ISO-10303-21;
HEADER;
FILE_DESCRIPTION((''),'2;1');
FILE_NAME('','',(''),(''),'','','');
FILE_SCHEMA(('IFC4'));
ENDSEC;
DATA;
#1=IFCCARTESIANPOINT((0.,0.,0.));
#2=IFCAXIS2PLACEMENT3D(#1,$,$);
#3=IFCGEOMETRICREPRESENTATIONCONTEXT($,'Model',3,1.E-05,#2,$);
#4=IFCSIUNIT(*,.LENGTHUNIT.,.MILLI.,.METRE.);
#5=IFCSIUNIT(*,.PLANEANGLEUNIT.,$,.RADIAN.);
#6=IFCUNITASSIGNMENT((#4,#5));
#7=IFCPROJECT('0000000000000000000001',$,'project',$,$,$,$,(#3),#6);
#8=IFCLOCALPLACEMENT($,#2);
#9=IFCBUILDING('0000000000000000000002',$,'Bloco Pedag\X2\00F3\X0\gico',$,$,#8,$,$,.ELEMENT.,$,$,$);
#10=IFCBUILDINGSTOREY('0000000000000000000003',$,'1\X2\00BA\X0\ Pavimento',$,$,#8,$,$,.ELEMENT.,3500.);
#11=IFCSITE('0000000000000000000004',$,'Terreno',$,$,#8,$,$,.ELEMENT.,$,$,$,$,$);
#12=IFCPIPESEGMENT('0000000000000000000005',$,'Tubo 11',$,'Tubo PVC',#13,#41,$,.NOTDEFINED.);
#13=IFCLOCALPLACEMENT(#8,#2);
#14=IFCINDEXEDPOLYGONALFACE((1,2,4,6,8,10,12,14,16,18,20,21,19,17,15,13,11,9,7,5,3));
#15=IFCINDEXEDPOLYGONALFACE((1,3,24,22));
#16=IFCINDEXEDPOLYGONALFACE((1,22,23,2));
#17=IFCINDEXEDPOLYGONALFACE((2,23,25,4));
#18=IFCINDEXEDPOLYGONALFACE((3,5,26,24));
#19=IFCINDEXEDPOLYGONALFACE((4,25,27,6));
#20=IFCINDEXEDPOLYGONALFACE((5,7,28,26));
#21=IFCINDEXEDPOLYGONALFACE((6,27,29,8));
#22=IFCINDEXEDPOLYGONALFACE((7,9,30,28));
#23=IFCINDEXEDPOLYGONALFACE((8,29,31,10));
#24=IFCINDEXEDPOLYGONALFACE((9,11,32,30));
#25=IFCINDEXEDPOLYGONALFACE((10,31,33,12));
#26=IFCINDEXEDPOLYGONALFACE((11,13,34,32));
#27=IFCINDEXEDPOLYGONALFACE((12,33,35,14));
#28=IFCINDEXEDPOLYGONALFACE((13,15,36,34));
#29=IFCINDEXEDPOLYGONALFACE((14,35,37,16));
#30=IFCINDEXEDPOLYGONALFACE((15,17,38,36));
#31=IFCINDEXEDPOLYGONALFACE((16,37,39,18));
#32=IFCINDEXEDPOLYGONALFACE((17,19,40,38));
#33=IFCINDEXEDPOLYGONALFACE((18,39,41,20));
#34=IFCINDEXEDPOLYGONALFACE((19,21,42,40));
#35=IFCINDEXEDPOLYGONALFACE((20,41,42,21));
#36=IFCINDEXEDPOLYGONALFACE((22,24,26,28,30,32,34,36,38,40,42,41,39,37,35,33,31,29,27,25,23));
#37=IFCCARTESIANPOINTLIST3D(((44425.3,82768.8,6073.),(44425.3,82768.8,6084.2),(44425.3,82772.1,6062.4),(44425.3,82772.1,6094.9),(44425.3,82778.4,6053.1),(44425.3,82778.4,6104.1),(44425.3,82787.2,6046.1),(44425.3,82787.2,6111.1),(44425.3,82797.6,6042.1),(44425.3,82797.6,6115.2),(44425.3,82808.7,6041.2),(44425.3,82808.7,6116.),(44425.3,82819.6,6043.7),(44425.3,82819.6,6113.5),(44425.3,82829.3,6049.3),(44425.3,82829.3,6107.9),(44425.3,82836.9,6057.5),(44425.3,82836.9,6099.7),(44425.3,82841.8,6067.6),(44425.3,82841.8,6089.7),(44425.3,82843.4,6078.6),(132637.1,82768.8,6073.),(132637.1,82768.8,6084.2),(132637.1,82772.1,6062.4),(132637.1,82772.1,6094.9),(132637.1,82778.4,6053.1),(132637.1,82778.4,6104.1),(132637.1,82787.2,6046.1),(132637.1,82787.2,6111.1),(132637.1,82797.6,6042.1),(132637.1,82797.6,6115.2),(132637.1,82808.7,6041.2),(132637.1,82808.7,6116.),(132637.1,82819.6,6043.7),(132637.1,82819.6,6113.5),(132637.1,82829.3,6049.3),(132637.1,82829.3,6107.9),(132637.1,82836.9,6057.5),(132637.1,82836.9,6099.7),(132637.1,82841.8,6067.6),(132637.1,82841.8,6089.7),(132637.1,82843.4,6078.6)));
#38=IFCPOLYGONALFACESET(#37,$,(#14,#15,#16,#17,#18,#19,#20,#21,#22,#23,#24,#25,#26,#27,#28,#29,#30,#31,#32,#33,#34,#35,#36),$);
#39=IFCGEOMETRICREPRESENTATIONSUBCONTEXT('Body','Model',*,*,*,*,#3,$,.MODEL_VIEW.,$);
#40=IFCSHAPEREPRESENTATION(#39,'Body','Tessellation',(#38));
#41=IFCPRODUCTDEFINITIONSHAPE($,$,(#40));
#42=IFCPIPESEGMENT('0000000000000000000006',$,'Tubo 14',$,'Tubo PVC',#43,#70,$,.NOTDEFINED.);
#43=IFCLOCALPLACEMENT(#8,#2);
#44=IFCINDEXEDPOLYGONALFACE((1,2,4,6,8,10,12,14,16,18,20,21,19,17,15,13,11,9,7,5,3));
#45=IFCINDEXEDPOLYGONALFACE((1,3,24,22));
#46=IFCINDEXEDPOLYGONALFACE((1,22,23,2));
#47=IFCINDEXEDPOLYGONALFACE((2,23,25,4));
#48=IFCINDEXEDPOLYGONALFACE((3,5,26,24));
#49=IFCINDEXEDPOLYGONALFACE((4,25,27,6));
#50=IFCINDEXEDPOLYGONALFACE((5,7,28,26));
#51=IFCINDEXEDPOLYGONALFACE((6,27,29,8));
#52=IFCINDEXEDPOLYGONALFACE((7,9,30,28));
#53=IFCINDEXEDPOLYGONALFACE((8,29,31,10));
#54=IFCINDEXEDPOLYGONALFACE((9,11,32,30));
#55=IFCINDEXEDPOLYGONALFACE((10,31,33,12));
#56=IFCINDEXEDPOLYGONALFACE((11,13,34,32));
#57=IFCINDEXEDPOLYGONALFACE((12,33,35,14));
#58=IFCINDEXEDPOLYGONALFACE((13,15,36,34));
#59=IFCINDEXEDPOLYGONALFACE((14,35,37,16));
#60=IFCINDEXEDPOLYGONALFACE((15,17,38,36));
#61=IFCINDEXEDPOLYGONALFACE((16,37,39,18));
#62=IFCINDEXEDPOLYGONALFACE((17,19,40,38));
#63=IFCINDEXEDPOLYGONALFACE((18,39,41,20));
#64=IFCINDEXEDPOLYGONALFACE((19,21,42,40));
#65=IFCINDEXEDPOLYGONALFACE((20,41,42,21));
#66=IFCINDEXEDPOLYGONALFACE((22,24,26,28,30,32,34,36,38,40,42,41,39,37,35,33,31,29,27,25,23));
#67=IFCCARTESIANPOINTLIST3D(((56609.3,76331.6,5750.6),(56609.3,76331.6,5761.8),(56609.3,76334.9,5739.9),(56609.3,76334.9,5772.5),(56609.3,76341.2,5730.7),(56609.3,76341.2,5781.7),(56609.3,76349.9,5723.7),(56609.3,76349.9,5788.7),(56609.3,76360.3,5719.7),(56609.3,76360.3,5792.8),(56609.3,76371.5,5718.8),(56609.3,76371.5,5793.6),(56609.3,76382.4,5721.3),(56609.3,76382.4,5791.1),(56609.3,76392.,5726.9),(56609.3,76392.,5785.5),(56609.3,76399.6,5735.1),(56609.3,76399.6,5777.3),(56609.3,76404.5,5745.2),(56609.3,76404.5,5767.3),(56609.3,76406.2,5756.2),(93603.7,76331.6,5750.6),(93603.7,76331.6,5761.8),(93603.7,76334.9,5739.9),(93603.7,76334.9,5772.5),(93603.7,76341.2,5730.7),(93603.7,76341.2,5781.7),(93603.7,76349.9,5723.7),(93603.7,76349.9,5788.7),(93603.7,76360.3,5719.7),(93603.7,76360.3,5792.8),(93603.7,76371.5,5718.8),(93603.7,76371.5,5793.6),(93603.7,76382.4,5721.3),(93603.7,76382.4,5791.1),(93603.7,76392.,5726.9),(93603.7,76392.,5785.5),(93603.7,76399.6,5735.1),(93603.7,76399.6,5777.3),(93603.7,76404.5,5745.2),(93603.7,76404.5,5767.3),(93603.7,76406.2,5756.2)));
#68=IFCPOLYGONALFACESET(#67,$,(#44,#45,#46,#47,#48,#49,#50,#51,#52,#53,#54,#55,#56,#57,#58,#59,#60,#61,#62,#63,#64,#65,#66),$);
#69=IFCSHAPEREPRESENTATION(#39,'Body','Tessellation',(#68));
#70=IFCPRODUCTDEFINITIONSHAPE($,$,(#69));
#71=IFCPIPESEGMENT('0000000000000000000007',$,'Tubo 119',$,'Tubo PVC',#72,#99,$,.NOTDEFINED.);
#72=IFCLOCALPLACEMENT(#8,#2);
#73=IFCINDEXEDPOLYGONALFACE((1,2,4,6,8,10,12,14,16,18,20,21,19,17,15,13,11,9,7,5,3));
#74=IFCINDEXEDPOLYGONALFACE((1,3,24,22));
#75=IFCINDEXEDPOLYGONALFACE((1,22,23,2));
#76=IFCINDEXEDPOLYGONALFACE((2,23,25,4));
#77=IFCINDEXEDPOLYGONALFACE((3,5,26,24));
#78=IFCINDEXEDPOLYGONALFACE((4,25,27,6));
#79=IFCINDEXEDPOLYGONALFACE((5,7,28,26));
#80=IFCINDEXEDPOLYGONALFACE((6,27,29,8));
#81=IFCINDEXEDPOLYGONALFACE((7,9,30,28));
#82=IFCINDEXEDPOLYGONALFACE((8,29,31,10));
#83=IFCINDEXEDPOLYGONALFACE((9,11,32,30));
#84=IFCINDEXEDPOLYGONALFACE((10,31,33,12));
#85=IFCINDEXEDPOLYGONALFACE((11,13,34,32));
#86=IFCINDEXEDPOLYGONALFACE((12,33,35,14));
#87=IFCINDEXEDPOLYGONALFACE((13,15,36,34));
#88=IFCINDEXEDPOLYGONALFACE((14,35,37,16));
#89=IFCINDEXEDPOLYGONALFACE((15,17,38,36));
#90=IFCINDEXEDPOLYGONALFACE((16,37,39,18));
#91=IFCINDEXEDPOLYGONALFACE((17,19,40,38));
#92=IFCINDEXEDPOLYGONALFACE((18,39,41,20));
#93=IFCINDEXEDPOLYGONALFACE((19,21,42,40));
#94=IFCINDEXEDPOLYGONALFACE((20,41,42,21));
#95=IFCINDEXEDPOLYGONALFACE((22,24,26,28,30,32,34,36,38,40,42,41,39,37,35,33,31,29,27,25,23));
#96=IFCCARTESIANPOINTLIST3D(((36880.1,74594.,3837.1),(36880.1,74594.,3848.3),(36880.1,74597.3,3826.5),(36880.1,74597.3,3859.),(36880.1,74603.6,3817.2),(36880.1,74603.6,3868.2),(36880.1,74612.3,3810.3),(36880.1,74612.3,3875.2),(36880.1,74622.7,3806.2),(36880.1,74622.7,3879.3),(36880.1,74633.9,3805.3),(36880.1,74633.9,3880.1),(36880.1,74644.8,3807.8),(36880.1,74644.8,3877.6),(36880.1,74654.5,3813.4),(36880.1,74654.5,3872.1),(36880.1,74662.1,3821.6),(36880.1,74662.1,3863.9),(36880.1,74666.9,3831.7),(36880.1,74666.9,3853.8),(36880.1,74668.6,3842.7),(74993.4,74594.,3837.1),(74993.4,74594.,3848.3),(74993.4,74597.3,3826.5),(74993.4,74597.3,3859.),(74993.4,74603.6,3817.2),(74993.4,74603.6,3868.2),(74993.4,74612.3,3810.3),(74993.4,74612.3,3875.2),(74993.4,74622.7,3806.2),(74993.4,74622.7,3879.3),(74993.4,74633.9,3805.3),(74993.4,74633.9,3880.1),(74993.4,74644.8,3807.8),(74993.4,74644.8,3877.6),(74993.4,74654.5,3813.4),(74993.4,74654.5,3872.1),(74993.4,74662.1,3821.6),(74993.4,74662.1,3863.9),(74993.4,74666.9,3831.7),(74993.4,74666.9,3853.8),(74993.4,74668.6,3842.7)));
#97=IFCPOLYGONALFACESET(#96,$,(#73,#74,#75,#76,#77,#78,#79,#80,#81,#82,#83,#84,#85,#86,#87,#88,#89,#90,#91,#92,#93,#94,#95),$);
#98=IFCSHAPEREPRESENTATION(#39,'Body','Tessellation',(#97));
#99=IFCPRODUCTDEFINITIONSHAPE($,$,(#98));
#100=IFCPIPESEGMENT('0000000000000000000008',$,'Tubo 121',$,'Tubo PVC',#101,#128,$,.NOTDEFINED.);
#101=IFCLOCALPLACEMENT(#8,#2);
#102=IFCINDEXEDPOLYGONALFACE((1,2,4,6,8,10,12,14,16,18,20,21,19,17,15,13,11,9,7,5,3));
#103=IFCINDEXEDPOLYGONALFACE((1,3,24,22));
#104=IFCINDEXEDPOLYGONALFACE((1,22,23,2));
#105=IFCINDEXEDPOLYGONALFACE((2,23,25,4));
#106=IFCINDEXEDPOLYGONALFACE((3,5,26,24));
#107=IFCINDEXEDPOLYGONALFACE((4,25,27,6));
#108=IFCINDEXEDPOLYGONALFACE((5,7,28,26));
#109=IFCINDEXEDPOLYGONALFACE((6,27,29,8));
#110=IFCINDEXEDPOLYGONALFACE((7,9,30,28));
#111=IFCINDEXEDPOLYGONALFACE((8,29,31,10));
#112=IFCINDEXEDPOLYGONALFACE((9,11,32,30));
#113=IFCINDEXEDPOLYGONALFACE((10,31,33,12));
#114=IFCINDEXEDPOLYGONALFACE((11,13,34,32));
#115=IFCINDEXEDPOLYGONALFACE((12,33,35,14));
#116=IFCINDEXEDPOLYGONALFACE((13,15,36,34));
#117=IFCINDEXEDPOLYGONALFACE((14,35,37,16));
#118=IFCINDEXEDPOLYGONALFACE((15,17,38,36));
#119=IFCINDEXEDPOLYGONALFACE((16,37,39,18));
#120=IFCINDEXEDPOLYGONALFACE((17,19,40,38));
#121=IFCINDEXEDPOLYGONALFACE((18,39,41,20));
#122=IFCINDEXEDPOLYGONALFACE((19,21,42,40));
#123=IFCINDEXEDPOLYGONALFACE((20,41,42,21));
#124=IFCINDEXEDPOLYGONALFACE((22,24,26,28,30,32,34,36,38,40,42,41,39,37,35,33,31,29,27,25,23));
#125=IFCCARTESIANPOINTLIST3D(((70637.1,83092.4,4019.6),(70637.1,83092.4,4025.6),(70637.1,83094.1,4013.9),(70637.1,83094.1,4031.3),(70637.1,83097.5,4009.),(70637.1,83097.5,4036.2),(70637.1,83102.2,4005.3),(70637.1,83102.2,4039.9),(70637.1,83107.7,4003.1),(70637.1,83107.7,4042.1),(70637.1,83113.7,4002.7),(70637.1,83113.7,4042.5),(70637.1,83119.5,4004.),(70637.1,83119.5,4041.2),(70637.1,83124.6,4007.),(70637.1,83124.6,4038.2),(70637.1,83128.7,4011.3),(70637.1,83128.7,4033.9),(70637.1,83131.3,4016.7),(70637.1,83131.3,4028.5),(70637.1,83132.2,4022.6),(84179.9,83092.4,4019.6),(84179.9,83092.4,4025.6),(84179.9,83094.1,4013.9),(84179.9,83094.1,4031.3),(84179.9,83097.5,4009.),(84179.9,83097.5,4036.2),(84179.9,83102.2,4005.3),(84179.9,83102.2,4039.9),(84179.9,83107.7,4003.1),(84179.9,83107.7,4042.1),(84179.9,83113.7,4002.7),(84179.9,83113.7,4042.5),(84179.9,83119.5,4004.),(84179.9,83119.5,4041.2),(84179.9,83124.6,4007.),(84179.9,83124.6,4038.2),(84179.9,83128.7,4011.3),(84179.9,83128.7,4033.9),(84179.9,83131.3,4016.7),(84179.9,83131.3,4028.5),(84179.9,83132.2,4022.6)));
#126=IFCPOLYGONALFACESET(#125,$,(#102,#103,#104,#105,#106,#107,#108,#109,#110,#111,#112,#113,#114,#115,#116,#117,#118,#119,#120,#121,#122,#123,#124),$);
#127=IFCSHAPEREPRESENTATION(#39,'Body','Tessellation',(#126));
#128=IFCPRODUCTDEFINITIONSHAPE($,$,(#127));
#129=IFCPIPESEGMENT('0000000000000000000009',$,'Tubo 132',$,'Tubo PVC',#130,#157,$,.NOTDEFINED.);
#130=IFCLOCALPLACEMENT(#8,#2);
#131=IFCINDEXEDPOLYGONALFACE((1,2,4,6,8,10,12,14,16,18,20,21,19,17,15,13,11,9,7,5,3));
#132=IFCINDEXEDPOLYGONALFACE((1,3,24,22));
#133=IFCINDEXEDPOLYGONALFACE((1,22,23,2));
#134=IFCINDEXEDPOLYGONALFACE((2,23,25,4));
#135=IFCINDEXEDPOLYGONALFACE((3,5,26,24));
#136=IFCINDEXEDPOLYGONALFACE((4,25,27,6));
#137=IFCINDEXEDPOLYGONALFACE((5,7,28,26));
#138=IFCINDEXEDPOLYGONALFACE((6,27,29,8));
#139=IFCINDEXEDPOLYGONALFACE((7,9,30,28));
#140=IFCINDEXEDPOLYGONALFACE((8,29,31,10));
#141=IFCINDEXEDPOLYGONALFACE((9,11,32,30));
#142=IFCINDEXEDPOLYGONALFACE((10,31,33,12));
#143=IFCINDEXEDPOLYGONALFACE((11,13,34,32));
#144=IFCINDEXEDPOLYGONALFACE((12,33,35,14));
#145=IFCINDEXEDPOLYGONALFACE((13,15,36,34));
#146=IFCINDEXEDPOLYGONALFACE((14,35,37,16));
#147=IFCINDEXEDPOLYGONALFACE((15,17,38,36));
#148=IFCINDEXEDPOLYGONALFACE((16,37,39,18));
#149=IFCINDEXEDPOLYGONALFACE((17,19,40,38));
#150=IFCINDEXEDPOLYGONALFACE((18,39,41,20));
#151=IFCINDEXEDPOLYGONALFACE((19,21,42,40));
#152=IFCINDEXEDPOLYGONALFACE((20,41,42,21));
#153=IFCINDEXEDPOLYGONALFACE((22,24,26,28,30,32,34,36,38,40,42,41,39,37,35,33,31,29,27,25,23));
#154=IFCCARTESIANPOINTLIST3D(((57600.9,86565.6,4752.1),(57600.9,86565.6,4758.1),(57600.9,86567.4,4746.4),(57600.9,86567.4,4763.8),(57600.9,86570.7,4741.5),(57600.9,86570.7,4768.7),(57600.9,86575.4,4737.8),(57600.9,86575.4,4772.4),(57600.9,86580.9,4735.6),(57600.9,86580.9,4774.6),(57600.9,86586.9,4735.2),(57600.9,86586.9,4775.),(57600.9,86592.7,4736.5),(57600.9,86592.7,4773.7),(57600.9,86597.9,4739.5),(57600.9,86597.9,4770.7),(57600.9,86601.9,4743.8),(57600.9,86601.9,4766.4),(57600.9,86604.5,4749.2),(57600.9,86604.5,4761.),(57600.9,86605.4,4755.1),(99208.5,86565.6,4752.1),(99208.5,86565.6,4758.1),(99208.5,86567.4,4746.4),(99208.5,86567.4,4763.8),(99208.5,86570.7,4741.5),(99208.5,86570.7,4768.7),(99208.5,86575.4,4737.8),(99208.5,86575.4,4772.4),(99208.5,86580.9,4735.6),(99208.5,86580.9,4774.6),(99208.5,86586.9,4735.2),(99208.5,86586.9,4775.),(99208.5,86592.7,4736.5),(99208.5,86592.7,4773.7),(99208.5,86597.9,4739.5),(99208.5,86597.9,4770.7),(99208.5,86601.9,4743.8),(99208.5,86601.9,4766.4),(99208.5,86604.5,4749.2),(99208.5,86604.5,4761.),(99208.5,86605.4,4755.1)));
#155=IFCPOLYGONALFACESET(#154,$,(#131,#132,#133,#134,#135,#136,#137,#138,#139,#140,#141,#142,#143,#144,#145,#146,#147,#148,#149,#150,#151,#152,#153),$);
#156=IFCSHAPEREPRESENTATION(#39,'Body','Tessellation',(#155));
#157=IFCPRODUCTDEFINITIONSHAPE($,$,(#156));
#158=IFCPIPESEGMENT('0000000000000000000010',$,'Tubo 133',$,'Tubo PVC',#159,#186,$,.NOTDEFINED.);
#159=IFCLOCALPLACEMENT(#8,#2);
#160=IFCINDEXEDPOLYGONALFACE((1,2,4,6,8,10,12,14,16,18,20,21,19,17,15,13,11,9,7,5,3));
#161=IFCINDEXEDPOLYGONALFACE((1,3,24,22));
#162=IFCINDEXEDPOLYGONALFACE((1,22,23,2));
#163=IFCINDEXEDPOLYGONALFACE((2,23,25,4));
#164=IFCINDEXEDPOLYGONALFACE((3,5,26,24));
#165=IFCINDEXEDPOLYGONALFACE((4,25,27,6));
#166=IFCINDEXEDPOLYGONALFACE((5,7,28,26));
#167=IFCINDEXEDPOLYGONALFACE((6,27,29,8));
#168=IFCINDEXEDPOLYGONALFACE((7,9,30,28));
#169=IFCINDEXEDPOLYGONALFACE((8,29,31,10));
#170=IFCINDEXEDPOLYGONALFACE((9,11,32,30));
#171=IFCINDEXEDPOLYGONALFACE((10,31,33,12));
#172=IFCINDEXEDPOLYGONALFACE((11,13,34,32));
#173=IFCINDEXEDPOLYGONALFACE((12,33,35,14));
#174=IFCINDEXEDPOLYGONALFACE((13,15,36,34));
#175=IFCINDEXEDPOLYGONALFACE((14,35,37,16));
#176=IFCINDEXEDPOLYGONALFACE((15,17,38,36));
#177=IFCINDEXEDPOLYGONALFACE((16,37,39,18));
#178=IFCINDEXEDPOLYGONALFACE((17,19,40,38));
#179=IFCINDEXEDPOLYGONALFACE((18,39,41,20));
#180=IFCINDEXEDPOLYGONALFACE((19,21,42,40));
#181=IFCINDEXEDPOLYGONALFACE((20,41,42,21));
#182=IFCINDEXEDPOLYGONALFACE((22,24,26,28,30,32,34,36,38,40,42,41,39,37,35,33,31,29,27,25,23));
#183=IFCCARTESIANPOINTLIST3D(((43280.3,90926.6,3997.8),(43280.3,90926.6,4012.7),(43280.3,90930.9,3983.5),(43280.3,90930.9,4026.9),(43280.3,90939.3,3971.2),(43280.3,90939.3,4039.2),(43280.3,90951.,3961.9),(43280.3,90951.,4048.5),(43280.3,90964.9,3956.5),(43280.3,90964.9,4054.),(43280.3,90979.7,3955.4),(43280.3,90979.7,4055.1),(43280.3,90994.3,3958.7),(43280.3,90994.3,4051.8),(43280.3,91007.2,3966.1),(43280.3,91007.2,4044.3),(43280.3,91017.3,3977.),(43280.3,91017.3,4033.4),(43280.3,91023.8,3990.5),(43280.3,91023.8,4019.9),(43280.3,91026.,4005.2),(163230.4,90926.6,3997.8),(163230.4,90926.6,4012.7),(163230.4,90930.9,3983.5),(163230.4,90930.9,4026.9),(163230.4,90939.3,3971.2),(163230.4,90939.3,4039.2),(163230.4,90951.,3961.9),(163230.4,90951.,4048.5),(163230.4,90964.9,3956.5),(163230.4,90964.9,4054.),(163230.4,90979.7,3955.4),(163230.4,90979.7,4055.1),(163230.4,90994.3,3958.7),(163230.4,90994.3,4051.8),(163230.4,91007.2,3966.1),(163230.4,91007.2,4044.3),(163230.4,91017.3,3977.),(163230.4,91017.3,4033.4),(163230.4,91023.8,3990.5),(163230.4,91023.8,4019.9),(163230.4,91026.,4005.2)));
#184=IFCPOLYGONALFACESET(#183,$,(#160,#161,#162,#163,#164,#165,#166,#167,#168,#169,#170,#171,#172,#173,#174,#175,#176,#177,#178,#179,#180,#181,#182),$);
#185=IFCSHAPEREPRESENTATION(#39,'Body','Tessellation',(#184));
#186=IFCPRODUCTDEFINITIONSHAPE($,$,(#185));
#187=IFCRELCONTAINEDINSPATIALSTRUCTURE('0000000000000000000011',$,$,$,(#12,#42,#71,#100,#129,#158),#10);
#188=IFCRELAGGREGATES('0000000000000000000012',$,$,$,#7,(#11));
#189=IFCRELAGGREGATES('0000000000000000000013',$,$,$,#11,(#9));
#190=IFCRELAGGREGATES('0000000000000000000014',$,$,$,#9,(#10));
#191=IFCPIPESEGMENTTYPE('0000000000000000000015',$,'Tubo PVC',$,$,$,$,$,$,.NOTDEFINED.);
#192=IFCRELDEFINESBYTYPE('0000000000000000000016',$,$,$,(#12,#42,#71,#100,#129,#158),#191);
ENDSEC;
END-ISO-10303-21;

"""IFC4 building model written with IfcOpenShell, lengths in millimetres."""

from ifc_helpers import new_model, si_unit, frame, origin, origin_2d, place, context, subcontext, project, spatial, circle, extrude, type_object, element, save


model = new_model("IFC4")

# Units and contexts
model_context = context("Model", 3, precision=1e-05, world=origin())
body_context = subcontext(model_context, "Body", "Model", "MODEL_VIEW")
ifc_project = project(units=[si_unit("LENGTHUNIT", "METRE", prefix="MILLI"), si_unit("PLANEANGLEUNIT", "RADIAN")], contexts=[model_context])

# Site, building, storey
placement = place(None, origin())
site = spatial("IfcSite", under=ifc_project, at=placement, Name="Terreno", CompositionType="ELEMENT")
building = spatial("IfcBuilding", under=site, at=placement, Name="Bloco Pedagógico", CompositionType="ELEMENT")
storey = spatial("IfcBuildingStorey", under=building, at=placement, Name="1º Pavimento", CompositionType="ELEMENT", Elevation=3500.0)

# Pipe segments
pipe_segment_type = type_object("IfcPipeSegmentType", Name="Tubo PVC", PredefinedType="NOTDEFINED")
pipe_segment_1_placement = place(None, frame((44425.3, 82805.9, 6078.6), z_axis=(1.0, 0.0, 0.0), x_axis=(0.0, 1.0, 0.0)))
element("IfcPipeSegment", 1, at=pipe_segment_1_placement, inside=storey, type_object=pipe_segment_type, Name="Tubo 11", ObjectType="Tubo PVC", PredefinedType="NOTDEFINED", context=body_context, shape_type="SweptSolid", body=[
    extrude(circle(Radius=37.5, at=origin_2d()), None, (0.0, 0.0, 1.0), 88211.7),
])
pipe_segment_2_placement = place(None, frame((56609.3, 76368.7, 5756.2), z_axis=(1.0, 0.0, 0.0), x_axis=(0.0, 1.0, 0.0)))
element("IfcPipeSegment", 2, at=pipe_segment_2_placement, inside=storey, type_object=pipe_segment_type, Name="Tubo 14", ObjectType="Tubo PVC", PredefinedType="NOTDEFINED", context=body_context, shape_type="SweptSolid", body=[
    extrude(circle(Radius=37.5, at=origin_2d()), None, (0.0, 0.0, 1.0), 36994.4),
])
pipe_segment_3_placement = place(None, frame((36880.1, 74631.1, 3842.7), z_axis=(1.0, 0.0, 0.0), x_axis=(0.0, 1.0, 0.0)))
element("IfcPipeSegment", 3, at=pipe_segment_3_placement, inside=storey, type_object=pipe_segment_type, Name="Tubo 119", ObjectType="Tubo PVC", PredefinedType="NOTDEFINED", context=body_context, shape_type="SweptSolid", body=[
    extrude(circle(Radius=37.5, at=origin_2d()), None, (0.0, 0.0, 1.0), 38113.3),
])
pipe_segment_4_placement = place(None, frame((70637.1, 83112.2, 4022.6), z_axis=(1.0, 0.0, 0.0), x_axis=(0.0, 1.0, 0.0)))
element("IfcPipeSegment", 4, at=pipe_segment_4_placement, inside=storey, type_object=pipe_segment_type, Name="Tubo 121", ObjectType="Tubo PVC", PredefinedType="NOTDEFINED", context=body_context, shape_type="SweptSolid", body=[
    extrude(circle(Radius=20.0, at=origin_2d()), None, (0.0, 0.0, 1.0), 13542.8),
])
pipe_segment_5_placement = place(None, frame((57600.9, 86585.4, 4755.1), z_axis=(1.0, 0.0, 0.0), x_axis=(0.0, 1.0, 0.0)))
element("IfcPipeSegment", 5, at=pipe_segment_5_placement, inside=storey, type_object=pipe_segment_type, Name="Tubo 132", ObjectType="Tubo PVC", PredefinedType="NOTDEFINED", context=body_context, shape_type="SweptSolid", body=[
    extrude(circle(Radius=20.0, at=origin_2d()), None, (0.0, 0.0, 1.0), 41607.6),
])
pipe_segment_6_placement = place(None, frame((43280.3, 90976.0, 4005.2), z_axis=(1.0, 0.0, 0.0), x_axis=(0.0, 1.0, 0.0)))
element("IfcPipeSegment", 6, at=pipe_segment_6_placement, inside=storey, type_object=pipe_segment_type, Name="Tubo 133", ObjectType="Tubo PVC", PredefinedType="NOTDEFINED", context=body_context, shape_type="SweptSolid", body=[
    extrude(circle(Radius=50.0, at=origin_2d()), None, (0.0, 0.0, 1.0), 119950.1),
])

save(model, "model.ifc")
